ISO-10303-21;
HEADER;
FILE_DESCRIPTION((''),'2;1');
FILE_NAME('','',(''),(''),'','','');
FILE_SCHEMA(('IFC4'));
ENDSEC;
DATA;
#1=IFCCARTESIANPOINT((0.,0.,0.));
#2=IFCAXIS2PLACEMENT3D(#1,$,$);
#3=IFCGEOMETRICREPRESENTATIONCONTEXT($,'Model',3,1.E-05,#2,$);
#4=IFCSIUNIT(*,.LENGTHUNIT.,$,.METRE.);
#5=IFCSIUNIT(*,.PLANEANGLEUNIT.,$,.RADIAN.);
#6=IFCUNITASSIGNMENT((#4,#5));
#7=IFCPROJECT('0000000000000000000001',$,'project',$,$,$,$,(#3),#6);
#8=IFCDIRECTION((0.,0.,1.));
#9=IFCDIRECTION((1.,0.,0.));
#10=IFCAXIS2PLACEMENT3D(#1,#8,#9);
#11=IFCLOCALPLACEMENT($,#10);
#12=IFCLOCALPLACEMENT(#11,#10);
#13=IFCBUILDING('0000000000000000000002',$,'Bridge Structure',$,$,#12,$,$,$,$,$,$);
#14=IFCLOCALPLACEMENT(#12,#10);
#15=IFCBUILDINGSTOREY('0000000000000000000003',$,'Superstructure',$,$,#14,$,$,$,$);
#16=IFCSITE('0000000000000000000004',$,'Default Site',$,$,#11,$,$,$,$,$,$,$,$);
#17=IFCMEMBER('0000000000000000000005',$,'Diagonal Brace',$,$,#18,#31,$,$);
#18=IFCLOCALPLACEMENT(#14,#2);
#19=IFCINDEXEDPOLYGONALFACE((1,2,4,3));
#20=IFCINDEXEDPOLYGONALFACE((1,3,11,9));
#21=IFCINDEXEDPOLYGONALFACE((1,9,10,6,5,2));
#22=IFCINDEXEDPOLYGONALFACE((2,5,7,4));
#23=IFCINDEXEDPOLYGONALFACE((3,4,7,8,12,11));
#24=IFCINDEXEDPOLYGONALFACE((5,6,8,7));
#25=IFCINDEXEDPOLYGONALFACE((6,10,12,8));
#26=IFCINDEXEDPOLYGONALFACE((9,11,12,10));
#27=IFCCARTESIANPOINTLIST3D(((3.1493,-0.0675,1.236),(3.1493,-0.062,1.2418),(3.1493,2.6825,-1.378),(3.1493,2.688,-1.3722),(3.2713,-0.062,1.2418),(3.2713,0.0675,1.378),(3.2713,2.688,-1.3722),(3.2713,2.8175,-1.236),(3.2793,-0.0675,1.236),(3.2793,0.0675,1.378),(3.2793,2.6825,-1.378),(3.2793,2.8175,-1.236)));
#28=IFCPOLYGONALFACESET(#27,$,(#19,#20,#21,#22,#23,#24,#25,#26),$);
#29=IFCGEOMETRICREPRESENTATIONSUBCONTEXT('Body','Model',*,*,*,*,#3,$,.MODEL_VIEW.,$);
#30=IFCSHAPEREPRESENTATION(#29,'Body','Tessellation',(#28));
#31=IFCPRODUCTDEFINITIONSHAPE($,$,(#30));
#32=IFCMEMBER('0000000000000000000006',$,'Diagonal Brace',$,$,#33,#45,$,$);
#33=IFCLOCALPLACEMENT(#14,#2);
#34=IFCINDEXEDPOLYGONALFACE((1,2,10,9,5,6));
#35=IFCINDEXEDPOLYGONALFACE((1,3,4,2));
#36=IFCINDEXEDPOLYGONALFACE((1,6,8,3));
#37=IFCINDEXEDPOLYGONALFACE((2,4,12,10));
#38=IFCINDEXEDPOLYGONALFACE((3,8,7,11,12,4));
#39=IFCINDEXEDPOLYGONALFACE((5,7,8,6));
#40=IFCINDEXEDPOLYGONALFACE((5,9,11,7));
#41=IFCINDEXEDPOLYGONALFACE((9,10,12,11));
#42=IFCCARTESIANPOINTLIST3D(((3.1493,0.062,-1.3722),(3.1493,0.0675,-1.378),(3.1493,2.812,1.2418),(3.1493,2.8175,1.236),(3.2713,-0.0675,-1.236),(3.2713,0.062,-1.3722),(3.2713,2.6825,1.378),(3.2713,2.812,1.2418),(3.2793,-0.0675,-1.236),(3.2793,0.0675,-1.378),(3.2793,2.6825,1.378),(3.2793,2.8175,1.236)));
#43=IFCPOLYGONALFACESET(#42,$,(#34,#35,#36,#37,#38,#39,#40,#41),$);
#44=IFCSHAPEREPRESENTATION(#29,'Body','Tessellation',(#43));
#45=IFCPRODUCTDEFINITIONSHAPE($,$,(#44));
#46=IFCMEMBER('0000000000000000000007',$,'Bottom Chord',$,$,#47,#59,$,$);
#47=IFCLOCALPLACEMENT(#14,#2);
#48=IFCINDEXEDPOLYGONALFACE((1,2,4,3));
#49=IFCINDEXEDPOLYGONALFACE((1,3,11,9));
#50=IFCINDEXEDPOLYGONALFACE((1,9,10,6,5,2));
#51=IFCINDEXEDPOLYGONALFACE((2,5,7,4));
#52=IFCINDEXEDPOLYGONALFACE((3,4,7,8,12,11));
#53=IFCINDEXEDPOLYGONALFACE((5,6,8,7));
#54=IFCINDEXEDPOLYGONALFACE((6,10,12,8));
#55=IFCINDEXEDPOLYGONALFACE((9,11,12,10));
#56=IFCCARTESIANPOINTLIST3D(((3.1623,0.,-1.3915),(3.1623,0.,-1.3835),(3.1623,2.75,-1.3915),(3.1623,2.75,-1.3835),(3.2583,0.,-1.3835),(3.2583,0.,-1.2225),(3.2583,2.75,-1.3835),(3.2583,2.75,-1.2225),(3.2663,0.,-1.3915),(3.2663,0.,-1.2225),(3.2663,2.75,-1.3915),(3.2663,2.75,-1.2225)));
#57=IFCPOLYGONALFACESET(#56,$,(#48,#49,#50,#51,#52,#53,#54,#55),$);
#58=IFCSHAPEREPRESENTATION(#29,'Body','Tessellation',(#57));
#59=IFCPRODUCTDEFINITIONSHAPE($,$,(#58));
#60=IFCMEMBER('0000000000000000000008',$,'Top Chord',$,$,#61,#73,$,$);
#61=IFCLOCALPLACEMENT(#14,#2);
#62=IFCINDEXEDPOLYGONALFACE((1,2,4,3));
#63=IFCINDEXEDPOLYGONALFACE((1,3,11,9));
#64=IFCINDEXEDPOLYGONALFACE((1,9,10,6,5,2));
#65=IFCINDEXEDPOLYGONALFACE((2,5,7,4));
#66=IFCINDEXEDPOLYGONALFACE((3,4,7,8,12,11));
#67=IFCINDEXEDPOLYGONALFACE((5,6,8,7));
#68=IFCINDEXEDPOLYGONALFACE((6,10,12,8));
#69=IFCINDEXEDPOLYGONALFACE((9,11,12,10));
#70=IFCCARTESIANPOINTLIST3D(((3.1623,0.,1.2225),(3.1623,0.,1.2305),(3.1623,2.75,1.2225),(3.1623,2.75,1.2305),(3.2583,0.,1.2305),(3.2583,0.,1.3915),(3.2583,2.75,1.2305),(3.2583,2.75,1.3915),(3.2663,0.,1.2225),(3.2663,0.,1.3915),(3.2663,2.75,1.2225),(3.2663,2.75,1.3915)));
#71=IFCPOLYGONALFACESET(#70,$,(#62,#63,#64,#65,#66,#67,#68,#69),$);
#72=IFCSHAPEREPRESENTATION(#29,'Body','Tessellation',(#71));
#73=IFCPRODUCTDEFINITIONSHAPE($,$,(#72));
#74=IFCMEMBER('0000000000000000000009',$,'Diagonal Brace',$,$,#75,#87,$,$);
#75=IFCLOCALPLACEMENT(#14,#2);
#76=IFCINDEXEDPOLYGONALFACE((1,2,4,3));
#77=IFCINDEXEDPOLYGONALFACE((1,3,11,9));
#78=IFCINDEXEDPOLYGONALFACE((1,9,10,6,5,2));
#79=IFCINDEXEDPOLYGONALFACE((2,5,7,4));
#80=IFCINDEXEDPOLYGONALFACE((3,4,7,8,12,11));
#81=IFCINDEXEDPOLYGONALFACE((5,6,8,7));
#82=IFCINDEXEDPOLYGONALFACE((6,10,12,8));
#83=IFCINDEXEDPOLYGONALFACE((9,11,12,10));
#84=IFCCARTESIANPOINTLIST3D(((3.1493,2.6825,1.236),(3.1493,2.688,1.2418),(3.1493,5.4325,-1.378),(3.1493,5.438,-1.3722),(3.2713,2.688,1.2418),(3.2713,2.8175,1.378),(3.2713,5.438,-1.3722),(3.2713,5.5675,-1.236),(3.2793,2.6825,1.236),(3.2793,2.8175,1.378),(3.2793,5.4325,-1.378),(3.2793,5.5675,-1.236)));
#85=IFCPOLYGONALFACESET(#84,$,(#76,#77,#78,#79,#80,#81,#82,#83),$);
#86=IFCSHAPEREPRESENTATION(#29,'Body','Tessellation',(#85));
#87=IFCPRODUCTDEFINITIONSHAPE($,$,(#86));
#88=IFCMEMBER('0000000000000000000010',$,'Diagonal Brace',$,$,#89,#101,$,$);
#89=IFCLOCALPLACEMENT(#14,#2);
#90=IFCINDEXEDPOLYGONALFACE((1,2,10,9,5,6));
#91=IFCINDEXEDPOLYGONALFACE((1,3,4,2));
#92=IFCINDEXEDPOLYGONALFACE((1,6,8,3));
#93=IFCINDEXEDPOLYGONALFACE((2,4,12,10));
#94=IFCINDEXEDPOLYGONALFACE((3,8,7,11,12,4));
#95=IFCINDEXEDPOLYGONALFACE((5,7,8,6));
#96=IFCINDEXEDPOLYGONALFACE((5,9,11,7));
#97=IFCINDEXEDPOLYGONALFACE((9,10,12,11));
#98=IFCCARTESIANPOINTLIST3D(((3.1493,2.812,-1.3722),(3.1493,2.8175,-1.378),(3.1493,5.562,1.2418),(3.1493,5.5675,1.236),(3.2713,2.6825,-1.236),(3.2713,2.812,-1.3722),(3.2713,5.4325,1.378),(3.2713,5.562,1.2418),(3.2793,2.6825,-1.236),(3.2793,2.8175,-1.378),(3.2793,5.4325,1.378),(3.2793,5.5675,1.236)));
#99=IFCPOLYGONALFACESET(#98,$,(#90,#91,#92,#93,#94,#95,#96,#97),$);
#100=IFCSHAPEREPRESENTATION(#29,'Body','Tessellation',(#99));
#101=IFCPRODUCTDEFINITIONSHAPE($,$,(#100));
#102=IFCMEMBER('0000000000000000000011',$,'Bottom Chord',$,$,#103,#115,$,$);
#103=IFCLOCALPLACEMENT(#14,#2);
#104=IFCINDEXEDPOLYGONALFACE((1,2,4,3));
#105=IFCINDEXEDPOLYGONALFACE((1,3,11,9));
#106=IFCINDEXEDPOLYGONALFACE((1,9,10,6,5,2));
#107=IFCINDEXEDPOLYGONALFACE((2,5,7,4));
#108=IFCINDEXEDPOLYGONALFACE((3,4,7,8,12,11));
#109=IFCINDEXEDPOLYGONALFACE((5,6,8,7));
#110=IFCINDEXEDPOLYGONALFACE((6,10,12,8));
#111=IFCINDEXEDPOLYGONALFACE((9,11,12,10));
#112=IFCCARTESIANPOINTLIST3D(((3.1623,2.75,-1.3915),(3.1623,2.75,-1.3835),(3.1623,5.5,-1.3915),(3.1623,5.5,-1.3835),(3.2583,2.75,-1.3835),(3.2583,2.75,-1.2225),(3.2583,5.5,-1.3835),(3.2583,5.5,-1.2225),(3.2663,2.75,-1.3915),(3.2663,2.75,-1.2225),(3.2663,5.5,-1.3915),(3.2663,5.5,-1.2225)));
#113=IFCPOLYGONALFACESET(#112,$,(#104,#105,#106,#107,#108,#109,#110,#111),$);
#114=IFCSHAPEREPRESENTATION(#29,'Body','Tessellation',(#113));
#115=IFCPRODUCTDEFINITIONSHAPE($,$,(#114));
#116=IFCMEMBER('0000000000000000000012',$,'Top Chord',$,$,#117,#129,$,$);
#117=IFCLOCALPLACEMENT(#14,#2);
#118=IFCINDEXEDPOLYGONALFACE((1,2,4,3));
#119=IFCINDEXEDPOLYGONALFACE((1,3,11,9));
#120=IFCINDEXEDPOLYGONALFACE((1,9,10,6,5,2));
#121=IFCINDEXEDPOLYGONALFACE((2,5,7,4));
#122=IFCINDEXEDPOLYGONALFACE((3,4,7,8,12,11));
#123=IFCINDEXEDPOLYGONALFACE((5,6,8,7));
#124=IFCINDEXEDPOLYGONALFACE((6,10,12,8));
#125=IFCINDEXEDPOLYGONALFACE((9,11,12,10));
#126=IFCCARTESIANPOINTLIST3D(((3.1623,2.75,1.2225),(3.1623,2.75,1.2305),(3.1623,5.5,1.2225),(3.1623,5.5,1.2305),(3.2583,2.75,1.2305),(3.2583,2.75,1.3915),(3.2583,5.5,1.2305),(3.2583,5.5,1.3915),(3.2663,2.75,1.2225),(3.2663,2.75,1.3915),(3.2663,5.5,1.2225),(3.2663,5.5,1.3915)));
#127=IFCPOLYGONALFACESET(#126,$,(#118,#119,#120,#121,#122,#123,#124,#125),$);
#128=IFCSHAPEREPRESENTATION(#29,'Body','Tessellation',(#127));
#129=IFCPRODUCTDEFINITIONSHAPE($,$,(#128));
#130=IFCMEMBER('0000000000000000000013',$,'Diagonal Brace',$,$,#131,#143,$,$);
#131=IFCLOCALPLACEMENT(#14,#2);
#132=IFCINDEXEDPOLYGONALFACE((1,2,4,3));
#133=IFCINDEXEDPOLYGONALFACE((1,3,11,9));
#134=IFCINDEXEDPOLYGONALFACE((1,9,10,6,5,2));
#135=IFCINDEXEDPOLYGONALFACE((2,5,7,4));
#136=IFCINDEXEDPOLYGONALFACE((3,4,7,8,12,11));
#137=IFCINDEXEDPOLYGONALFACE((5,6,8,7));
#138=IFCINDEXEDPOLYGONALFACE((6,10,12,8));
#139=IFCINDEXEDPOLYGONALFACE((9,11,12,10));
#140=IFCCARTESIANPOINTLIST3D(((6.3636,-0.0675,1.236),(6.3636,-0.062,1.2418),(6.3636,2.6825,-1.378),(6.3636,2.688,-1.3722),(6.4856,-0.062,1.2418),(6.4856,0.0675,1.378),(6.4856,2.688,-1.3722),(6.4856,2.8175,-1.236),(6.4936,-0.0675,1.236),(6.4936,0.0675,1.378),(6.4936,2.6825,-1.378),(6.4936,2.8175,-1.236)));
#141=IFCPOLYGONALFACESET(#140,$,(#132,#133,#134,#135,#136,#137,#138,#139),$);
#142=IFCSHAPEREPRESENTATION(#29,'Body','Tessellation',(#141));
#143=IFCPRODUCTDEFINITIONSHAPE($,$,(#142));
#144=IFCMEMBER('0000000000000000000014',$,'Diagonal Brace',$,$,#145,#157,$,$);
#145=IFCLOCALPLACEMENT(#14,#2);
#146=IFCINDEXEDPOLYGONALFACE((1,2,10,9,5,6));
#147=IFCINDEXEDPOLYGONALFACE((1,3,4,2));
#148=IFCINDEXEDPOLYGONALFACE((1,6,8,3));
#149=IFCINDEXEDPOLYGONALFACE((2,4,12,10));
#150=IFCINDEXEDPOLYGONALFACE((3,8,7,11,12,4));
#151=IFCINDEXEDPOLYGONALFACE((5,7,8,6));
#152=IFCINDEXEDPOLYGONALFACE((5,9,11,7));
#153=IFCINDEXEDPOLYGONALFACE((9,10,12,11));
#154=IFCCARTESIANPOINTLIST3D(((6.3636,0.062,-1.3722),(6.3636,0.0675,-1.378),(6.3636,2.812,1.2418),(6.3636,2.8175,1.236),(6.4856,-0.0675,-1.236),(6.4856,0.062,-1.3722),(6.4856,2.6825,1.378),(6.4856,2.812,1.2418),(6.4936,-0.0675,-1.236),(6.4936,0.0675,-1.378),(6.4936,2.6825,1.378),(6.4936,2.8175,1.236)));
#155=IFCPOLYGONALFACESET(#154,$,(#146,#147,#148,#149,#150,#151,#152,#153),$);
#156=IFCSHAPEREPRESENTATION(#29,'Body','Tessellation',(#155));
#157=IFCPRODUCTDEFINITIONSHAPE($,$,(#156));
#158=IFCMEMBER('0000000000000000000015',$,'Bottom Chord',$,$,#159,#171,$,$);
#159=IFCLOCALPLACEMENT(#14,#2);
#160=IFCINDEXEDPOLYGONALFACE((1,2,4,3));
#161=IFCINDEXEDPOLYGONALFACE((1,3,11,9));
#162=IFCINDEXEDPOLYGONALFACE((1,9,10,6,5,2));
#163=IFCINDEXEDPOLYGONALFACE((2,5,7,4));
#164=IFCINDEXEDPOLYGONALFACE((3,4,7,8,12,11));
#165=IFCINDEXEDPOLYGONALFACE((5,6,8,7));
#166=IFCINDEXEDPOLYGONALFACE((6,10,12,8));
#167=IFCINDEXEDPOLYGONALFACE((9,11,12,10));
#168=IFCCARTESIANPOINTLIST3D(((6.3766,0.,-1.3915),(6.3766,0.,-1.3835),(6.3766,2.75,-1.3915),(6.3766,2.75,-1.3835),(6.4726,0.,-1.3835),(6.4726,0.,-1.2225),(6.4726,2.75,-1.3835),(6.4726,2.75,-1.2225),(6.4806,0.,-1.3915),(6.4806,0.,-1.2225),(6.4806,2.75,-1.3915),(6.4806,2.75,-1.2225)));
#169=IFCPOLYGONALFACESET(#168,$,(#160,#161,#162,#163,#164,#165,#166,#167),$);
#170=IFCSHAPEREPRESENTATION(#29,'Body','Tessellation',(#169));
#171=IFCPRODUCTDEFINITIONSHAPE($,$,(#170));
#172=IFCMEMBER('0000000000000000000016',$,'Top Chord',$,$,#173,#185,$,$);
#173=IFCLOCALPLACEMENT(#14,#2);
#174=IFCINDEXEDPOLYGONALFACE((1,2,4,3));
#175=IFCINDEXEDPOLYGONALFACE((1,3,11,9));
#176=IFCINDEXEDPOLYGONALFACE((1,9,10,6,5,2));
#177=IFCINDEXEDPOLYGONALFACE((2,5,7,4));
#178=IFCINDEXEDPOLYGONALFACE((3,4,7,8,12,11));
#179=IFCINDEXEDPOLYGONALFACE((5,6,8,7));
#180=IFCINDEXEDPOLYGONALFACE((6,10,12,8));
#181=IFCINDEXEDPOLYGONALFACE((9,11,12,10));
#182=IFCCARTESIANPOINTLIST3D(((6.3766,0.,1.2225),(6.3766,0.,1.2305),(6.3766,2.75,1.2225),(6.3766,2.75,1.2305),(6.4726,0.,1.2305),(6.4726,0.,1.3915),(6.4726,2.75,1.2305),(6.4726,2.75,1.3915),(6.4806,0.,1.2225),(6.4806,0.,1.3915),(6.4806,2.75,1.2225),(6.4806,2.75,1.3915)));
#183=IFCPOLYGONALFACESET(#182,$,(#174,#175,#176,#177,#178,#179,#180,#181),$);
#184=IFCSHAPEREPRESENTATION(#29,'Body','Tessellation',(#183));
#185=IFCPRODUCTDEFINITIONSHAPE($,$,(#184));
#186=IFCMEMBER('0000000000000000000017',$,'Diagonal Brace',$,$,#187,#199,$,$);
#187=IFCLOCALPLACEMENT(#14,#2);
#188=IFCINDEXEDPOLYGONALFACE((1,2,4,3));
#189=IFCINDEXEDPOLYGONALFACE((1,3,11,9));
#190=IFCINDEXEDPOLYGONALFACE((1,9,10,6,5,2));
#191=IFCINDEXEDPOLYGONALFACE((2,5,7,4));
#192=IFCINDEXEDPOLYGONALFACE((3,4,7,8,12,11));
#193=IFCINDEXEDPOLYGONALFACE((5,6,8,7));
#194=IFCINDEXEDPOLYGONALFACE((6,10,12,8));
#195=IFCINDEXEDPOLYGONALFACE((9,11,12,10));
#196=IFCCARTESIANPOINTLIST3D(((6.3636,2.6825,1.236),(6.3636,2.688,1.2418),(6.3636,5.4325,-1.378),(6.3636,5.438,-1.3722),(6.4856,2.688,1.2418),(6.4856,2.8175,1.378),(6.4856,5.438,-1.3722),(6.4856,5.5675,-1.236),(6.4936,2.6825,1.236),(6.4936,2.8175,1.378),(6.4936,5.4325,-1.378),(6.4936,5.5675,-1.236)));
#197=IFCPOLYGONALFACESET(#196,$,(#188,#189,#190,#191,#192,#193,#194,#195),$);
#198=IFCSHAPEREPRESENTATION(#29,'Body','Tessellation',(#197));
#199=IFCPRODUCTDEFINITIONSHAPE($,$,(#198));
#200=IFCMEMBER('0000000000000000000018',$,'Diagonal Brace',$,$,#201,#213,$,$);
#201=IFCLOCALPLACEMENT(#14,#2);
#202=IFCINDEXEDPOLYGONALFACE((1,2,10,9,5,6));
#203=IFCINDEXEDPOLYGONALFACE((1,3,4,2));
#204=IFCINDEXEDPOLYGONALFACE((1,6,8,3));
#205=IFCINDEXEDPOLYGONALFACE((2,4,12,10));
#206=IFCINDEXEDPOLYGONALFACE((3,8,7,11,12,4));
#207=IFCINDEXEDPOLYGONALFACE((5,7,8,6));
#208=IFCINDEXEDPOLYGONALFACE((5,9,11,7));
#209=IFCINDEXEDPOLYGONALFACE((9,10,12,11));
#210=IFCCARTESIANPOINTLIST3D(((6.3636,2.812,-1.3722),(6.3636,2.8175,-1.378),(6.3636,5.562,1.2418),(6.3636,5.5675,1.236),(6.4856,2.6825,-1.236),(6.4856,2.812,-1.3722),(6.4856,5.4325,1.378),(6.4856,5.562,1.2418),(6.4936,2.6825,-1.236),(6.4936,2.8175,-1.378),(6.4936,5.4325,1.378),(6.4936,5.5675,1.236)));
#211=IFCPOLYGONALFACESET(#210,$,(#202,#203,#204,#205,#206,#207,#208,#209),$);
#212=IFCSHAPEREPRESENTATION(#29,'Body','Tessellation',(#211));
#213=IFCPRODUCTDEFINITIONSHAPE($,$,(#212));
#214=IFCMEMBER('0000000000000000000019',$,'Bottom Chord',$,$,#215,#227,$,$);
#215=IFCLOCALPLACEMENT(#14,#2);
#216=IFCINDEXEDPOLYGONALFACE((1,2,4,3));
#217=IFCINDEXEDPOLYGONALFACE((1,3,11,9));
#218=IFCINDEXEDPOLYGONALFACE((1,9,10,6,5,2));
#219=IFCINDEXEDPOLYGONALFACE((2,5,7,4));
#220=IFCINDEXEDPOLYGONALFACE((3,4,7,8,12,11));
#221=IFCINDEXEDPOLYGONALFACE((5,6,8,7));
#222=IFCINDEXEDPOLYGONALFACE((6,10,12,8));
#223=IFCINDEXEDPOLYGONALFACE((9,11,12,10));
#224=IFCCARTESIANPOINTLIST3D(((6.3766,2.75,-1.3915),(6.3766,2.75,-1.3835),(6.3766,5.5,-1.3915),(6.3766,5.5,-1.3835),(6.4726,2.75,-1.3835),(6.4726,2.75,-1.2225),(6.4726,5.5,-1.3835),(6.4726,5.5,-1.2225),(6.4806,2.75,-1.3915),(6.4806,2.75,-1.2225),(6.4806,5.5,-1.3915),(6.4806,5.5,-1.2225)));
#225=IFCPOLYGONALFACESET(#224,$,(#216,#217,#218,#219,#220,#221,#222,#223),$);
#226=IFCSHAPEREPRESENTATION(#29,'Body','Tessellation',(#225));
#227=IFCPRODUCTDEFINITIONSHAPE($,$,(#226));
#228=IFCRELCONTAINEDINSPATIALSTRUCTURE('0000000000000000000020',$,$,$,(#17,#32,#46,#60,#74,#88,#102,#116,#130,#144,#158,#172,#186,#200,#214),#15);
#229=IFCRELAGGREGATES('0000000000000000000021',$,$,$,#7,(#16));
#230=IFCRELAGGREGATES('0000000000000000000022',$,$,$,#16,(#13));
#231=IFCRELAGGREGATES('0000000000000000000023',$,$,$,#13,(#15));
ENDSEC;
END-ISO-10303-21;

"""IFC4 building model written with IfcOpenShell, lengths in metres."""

from ifc_helpers import new_model, si_unit, frame, origin, origin_with_axes, origin_2d_with_axis, place, context, subcontext, project, spatial, l_section, extrude, element, save


model = new_model("IFC4")

# Units and contexts
model_context = context("Model", 3, precision=1e-05, world=origin())
body_context = subcontext(model_context, "Body", "Model", "MODEL_VIEW")
ifc_project = project(units=[si_unit("LENGTHUNIT", "METRE"), si_unit("PLANEANGLEUNIT", "RADIAN")], contexts=[model_context])

# Site, building, storey
site_placement = place(None, origin_with_axes())
site = spatial("IfcSite", under=ifc_project, at=site_placement, Name="Default Site")
building_placement = place(site_placement, origin_with_axes())
building = spatial("IfcBuilding", under=site, at=building_placement, Name="Bridge Structure")
storey_placement = place(building_placement, origin_with_axes())
storey = spatial("IfcBuildingStorey", under=building, at=storey_placement, Name="Superstructure")

# Members
for number, where, z_axis, x_axis, name in (
    (1, (3.2143, 0.0, 1.307), (0.0, 0.724802, -0.688957), (-1.0, 0.0, 0.0), "Diagonal Brace"),
    (2, (3.2143, 0.0, -1.307), (0.0, 0.724802, 0.688957), (-1.0, 0.0, 0.0), "Diagonal Brace"),
):
    element("IfcMember", number, at=place(storey_placement, frame(where, z_axis=z_axis, x_axis=x_axis)), inside=storey, Name=name, context=body_context, shape_type="SweptSolid", body=[
        extrude(l_section(Depth=0.196, Width=0.13, Thickness=0.008, at=origin_2d_with_axis()), origin_with_axes(), (0.0, 0.0, 1.0), 3.7941),
    ])
for number, where, z_axis, x_axis, name in (
    (3, (3.2143, 0.0, -1.307), (0.0, 1.0, 0.0), (-1.0, 0.0, 0.0), "Bottom Chord"),
    (4, (3.2143, 0.0, 1.307), (0.0, 1.0, 0.0), (-1.0, 0.0, 0.0), "Top Chord"),
):
    element("IfcMember", number, at=place(storey_placement, frame(where, z_axis=z_axis, x_axis=x_axis)), inside=storey, Name=name, context=body_context, shape_type="SweptSolid", body=[
        extrude(l_section(Depth=0.169, Width=0.104, Thickness=0.008, at=origin_2d_with_axis()), origin_with_axes(), (0.0, 0.0, 1.0), 2.75),
    ])
for number, where, z_axis, x_axis, name in (
    (5, (3.2143, 2.75, 1.307), (0.0, 0.724802, -0.688957), (-1.0, 0.0, 0.0), "Diagonal Brace"),
    (6, (3.2143, 2.75, -1.307), (0.0, 0.724802, 0.688957), (-1.0, 0.0, 0.0), "Diagonal Brace"),
):
    element("IfcMember", number, at=place(storey_placement, frame(where, z_axis=z_axis, x_axis=x_axis)), inside=storey, Name=name, context=body_context, shape_type="SweptSolid", body=[
        extrude(l_section(Depth=0.196, Width=0.13, Thickness=0.008, at=origin_2d_with_axis()), origin_with_axes(), (0.0, 0.0, 1.0), 3.7941),
    ])
for number, where, z_axis, x_axis, name in (
    (7, (3.2143, 2.75, -1.307), (0.0, 1.0, 0.0), (-1.0, 0.0, 0.0), "Bottom Chord"),
    (8, (3.2143, 2.75, 1.307), (0.0, 1.0, 0.0), (-1.0, 0.0, 0.0), "Top Chord"),
):
    element("IfcMember", number, at=place(storey_placement, frame(where, z_axis=z_axis, x_axis=x_axis)), inside=storey, Name=name, context=body_context, shape_type="SweptSolid", body=[
        extrude(l_section(Depth=0.169, Width=0.104, Thickness=0.008, at=origin_2d_with_axis()), origin_with_axes(), (0.0, 0.0, 1.0), 2.75),
    ])
for number, where, z_axis, x_axis, name in (
    (9, (6.4286, 0.0, 1.307), (0.0, 0.724802, -0.688957), (-1.0, 0.0, 0.0), "Diagonal Brace"),
    (10, (6.4286, 0.0, -1.307), (0.0, 0.724802, 0.688957), (-1.0, 0.0, 0.0), "Diagonal Brace"),
):
    element("IfcMember", number, at=place(storey_placement, frame(where, z_axis=z_axis, x_axis=x_axis)), inside=storey, Name=name, context=body_context, shape_type="SweptSolid", body=[
        extrude(l_section(Depth=0.196, Width=0.13, Thickness=0.008, at=origin_2d_with_axis()), origin_with_axes(), (0.0, 0.0, 1.0), 3.7941),
    ])
for number, where, z_axis, x_axis, name in (
    (11, (6.4286, 0.0, -1.307), (0.0, 1.0, 0.0), (-1.0, 0.0, 0.0), "Bottom Chord"),
    (12, (6.4286, 0.0, 1.307), (0.0, 1.0, 0.0), (-1.0, 0.0, 0.0), "Top Chord"),
):
    element("IfcMember", number, at=place(storey_placement, frame(where, z_axis=z_axis, x_axis=x_axis)), inside=storey, Name=name, context=body_context, shape_type="SweptSolid", body=[
        extrude(l_section(Depth=0.169, Width=0.104, Thickness=0.008, at=origin_2d_with_axis()), origin_with_axes(), (0.0, 0.0, 1.0), 2.75),
    ])
for number, where, z_axis, x_axis, name in (
    (13, (6.4286, 2.75, 1.307), (0.0, 0.724802, -0.688957), (-1.0, 0.0, 0.0), "Diagonal Brace"),
    (14, (6.4286, 2.75, -1.307), (0.0, 0.724802, 0.688957), (-1.0, 0.0, 0.0), "Diagonal Brace"),
):
    element("IfcMember", number, at=place(storey_placement, frame(where, z_axis=z_axis, x_axis=x_axis)), inside=storey, Name=name, context=body_context, shape_type="SweptSolid", body=[
        extrude(l_section(Depth=0.196, Width=0.13, Thickness=0.008, at=origin_2d_with_axis()), origin_with_axes(), (0.0, 0.0, 1.0), 3.7941),
    ])
for number, where, z_axis, x_axis, name in (
    (15, (6.4286, 2.75, -1.307), (0.0, 1.0, 0.0), (-1.0, 0.0, 0.0), "Bottom Chord"),
):
    element("IfcMember", number, at=place(storey_placement, frame(where, z_axis=z_axis, x_axis=x_axis)), inside=storey, Name=name, context=body_context, shape_type="SweptSolid", body=[
        extrude(l_section(Depth=0.169, Width=0.104, Thickness=0.008, at=origin_2d_with_axis()), origin_with_axes(), (0.0, 0.0, 1.0), 2.75),
    ])

save(model, "model.ifc")
